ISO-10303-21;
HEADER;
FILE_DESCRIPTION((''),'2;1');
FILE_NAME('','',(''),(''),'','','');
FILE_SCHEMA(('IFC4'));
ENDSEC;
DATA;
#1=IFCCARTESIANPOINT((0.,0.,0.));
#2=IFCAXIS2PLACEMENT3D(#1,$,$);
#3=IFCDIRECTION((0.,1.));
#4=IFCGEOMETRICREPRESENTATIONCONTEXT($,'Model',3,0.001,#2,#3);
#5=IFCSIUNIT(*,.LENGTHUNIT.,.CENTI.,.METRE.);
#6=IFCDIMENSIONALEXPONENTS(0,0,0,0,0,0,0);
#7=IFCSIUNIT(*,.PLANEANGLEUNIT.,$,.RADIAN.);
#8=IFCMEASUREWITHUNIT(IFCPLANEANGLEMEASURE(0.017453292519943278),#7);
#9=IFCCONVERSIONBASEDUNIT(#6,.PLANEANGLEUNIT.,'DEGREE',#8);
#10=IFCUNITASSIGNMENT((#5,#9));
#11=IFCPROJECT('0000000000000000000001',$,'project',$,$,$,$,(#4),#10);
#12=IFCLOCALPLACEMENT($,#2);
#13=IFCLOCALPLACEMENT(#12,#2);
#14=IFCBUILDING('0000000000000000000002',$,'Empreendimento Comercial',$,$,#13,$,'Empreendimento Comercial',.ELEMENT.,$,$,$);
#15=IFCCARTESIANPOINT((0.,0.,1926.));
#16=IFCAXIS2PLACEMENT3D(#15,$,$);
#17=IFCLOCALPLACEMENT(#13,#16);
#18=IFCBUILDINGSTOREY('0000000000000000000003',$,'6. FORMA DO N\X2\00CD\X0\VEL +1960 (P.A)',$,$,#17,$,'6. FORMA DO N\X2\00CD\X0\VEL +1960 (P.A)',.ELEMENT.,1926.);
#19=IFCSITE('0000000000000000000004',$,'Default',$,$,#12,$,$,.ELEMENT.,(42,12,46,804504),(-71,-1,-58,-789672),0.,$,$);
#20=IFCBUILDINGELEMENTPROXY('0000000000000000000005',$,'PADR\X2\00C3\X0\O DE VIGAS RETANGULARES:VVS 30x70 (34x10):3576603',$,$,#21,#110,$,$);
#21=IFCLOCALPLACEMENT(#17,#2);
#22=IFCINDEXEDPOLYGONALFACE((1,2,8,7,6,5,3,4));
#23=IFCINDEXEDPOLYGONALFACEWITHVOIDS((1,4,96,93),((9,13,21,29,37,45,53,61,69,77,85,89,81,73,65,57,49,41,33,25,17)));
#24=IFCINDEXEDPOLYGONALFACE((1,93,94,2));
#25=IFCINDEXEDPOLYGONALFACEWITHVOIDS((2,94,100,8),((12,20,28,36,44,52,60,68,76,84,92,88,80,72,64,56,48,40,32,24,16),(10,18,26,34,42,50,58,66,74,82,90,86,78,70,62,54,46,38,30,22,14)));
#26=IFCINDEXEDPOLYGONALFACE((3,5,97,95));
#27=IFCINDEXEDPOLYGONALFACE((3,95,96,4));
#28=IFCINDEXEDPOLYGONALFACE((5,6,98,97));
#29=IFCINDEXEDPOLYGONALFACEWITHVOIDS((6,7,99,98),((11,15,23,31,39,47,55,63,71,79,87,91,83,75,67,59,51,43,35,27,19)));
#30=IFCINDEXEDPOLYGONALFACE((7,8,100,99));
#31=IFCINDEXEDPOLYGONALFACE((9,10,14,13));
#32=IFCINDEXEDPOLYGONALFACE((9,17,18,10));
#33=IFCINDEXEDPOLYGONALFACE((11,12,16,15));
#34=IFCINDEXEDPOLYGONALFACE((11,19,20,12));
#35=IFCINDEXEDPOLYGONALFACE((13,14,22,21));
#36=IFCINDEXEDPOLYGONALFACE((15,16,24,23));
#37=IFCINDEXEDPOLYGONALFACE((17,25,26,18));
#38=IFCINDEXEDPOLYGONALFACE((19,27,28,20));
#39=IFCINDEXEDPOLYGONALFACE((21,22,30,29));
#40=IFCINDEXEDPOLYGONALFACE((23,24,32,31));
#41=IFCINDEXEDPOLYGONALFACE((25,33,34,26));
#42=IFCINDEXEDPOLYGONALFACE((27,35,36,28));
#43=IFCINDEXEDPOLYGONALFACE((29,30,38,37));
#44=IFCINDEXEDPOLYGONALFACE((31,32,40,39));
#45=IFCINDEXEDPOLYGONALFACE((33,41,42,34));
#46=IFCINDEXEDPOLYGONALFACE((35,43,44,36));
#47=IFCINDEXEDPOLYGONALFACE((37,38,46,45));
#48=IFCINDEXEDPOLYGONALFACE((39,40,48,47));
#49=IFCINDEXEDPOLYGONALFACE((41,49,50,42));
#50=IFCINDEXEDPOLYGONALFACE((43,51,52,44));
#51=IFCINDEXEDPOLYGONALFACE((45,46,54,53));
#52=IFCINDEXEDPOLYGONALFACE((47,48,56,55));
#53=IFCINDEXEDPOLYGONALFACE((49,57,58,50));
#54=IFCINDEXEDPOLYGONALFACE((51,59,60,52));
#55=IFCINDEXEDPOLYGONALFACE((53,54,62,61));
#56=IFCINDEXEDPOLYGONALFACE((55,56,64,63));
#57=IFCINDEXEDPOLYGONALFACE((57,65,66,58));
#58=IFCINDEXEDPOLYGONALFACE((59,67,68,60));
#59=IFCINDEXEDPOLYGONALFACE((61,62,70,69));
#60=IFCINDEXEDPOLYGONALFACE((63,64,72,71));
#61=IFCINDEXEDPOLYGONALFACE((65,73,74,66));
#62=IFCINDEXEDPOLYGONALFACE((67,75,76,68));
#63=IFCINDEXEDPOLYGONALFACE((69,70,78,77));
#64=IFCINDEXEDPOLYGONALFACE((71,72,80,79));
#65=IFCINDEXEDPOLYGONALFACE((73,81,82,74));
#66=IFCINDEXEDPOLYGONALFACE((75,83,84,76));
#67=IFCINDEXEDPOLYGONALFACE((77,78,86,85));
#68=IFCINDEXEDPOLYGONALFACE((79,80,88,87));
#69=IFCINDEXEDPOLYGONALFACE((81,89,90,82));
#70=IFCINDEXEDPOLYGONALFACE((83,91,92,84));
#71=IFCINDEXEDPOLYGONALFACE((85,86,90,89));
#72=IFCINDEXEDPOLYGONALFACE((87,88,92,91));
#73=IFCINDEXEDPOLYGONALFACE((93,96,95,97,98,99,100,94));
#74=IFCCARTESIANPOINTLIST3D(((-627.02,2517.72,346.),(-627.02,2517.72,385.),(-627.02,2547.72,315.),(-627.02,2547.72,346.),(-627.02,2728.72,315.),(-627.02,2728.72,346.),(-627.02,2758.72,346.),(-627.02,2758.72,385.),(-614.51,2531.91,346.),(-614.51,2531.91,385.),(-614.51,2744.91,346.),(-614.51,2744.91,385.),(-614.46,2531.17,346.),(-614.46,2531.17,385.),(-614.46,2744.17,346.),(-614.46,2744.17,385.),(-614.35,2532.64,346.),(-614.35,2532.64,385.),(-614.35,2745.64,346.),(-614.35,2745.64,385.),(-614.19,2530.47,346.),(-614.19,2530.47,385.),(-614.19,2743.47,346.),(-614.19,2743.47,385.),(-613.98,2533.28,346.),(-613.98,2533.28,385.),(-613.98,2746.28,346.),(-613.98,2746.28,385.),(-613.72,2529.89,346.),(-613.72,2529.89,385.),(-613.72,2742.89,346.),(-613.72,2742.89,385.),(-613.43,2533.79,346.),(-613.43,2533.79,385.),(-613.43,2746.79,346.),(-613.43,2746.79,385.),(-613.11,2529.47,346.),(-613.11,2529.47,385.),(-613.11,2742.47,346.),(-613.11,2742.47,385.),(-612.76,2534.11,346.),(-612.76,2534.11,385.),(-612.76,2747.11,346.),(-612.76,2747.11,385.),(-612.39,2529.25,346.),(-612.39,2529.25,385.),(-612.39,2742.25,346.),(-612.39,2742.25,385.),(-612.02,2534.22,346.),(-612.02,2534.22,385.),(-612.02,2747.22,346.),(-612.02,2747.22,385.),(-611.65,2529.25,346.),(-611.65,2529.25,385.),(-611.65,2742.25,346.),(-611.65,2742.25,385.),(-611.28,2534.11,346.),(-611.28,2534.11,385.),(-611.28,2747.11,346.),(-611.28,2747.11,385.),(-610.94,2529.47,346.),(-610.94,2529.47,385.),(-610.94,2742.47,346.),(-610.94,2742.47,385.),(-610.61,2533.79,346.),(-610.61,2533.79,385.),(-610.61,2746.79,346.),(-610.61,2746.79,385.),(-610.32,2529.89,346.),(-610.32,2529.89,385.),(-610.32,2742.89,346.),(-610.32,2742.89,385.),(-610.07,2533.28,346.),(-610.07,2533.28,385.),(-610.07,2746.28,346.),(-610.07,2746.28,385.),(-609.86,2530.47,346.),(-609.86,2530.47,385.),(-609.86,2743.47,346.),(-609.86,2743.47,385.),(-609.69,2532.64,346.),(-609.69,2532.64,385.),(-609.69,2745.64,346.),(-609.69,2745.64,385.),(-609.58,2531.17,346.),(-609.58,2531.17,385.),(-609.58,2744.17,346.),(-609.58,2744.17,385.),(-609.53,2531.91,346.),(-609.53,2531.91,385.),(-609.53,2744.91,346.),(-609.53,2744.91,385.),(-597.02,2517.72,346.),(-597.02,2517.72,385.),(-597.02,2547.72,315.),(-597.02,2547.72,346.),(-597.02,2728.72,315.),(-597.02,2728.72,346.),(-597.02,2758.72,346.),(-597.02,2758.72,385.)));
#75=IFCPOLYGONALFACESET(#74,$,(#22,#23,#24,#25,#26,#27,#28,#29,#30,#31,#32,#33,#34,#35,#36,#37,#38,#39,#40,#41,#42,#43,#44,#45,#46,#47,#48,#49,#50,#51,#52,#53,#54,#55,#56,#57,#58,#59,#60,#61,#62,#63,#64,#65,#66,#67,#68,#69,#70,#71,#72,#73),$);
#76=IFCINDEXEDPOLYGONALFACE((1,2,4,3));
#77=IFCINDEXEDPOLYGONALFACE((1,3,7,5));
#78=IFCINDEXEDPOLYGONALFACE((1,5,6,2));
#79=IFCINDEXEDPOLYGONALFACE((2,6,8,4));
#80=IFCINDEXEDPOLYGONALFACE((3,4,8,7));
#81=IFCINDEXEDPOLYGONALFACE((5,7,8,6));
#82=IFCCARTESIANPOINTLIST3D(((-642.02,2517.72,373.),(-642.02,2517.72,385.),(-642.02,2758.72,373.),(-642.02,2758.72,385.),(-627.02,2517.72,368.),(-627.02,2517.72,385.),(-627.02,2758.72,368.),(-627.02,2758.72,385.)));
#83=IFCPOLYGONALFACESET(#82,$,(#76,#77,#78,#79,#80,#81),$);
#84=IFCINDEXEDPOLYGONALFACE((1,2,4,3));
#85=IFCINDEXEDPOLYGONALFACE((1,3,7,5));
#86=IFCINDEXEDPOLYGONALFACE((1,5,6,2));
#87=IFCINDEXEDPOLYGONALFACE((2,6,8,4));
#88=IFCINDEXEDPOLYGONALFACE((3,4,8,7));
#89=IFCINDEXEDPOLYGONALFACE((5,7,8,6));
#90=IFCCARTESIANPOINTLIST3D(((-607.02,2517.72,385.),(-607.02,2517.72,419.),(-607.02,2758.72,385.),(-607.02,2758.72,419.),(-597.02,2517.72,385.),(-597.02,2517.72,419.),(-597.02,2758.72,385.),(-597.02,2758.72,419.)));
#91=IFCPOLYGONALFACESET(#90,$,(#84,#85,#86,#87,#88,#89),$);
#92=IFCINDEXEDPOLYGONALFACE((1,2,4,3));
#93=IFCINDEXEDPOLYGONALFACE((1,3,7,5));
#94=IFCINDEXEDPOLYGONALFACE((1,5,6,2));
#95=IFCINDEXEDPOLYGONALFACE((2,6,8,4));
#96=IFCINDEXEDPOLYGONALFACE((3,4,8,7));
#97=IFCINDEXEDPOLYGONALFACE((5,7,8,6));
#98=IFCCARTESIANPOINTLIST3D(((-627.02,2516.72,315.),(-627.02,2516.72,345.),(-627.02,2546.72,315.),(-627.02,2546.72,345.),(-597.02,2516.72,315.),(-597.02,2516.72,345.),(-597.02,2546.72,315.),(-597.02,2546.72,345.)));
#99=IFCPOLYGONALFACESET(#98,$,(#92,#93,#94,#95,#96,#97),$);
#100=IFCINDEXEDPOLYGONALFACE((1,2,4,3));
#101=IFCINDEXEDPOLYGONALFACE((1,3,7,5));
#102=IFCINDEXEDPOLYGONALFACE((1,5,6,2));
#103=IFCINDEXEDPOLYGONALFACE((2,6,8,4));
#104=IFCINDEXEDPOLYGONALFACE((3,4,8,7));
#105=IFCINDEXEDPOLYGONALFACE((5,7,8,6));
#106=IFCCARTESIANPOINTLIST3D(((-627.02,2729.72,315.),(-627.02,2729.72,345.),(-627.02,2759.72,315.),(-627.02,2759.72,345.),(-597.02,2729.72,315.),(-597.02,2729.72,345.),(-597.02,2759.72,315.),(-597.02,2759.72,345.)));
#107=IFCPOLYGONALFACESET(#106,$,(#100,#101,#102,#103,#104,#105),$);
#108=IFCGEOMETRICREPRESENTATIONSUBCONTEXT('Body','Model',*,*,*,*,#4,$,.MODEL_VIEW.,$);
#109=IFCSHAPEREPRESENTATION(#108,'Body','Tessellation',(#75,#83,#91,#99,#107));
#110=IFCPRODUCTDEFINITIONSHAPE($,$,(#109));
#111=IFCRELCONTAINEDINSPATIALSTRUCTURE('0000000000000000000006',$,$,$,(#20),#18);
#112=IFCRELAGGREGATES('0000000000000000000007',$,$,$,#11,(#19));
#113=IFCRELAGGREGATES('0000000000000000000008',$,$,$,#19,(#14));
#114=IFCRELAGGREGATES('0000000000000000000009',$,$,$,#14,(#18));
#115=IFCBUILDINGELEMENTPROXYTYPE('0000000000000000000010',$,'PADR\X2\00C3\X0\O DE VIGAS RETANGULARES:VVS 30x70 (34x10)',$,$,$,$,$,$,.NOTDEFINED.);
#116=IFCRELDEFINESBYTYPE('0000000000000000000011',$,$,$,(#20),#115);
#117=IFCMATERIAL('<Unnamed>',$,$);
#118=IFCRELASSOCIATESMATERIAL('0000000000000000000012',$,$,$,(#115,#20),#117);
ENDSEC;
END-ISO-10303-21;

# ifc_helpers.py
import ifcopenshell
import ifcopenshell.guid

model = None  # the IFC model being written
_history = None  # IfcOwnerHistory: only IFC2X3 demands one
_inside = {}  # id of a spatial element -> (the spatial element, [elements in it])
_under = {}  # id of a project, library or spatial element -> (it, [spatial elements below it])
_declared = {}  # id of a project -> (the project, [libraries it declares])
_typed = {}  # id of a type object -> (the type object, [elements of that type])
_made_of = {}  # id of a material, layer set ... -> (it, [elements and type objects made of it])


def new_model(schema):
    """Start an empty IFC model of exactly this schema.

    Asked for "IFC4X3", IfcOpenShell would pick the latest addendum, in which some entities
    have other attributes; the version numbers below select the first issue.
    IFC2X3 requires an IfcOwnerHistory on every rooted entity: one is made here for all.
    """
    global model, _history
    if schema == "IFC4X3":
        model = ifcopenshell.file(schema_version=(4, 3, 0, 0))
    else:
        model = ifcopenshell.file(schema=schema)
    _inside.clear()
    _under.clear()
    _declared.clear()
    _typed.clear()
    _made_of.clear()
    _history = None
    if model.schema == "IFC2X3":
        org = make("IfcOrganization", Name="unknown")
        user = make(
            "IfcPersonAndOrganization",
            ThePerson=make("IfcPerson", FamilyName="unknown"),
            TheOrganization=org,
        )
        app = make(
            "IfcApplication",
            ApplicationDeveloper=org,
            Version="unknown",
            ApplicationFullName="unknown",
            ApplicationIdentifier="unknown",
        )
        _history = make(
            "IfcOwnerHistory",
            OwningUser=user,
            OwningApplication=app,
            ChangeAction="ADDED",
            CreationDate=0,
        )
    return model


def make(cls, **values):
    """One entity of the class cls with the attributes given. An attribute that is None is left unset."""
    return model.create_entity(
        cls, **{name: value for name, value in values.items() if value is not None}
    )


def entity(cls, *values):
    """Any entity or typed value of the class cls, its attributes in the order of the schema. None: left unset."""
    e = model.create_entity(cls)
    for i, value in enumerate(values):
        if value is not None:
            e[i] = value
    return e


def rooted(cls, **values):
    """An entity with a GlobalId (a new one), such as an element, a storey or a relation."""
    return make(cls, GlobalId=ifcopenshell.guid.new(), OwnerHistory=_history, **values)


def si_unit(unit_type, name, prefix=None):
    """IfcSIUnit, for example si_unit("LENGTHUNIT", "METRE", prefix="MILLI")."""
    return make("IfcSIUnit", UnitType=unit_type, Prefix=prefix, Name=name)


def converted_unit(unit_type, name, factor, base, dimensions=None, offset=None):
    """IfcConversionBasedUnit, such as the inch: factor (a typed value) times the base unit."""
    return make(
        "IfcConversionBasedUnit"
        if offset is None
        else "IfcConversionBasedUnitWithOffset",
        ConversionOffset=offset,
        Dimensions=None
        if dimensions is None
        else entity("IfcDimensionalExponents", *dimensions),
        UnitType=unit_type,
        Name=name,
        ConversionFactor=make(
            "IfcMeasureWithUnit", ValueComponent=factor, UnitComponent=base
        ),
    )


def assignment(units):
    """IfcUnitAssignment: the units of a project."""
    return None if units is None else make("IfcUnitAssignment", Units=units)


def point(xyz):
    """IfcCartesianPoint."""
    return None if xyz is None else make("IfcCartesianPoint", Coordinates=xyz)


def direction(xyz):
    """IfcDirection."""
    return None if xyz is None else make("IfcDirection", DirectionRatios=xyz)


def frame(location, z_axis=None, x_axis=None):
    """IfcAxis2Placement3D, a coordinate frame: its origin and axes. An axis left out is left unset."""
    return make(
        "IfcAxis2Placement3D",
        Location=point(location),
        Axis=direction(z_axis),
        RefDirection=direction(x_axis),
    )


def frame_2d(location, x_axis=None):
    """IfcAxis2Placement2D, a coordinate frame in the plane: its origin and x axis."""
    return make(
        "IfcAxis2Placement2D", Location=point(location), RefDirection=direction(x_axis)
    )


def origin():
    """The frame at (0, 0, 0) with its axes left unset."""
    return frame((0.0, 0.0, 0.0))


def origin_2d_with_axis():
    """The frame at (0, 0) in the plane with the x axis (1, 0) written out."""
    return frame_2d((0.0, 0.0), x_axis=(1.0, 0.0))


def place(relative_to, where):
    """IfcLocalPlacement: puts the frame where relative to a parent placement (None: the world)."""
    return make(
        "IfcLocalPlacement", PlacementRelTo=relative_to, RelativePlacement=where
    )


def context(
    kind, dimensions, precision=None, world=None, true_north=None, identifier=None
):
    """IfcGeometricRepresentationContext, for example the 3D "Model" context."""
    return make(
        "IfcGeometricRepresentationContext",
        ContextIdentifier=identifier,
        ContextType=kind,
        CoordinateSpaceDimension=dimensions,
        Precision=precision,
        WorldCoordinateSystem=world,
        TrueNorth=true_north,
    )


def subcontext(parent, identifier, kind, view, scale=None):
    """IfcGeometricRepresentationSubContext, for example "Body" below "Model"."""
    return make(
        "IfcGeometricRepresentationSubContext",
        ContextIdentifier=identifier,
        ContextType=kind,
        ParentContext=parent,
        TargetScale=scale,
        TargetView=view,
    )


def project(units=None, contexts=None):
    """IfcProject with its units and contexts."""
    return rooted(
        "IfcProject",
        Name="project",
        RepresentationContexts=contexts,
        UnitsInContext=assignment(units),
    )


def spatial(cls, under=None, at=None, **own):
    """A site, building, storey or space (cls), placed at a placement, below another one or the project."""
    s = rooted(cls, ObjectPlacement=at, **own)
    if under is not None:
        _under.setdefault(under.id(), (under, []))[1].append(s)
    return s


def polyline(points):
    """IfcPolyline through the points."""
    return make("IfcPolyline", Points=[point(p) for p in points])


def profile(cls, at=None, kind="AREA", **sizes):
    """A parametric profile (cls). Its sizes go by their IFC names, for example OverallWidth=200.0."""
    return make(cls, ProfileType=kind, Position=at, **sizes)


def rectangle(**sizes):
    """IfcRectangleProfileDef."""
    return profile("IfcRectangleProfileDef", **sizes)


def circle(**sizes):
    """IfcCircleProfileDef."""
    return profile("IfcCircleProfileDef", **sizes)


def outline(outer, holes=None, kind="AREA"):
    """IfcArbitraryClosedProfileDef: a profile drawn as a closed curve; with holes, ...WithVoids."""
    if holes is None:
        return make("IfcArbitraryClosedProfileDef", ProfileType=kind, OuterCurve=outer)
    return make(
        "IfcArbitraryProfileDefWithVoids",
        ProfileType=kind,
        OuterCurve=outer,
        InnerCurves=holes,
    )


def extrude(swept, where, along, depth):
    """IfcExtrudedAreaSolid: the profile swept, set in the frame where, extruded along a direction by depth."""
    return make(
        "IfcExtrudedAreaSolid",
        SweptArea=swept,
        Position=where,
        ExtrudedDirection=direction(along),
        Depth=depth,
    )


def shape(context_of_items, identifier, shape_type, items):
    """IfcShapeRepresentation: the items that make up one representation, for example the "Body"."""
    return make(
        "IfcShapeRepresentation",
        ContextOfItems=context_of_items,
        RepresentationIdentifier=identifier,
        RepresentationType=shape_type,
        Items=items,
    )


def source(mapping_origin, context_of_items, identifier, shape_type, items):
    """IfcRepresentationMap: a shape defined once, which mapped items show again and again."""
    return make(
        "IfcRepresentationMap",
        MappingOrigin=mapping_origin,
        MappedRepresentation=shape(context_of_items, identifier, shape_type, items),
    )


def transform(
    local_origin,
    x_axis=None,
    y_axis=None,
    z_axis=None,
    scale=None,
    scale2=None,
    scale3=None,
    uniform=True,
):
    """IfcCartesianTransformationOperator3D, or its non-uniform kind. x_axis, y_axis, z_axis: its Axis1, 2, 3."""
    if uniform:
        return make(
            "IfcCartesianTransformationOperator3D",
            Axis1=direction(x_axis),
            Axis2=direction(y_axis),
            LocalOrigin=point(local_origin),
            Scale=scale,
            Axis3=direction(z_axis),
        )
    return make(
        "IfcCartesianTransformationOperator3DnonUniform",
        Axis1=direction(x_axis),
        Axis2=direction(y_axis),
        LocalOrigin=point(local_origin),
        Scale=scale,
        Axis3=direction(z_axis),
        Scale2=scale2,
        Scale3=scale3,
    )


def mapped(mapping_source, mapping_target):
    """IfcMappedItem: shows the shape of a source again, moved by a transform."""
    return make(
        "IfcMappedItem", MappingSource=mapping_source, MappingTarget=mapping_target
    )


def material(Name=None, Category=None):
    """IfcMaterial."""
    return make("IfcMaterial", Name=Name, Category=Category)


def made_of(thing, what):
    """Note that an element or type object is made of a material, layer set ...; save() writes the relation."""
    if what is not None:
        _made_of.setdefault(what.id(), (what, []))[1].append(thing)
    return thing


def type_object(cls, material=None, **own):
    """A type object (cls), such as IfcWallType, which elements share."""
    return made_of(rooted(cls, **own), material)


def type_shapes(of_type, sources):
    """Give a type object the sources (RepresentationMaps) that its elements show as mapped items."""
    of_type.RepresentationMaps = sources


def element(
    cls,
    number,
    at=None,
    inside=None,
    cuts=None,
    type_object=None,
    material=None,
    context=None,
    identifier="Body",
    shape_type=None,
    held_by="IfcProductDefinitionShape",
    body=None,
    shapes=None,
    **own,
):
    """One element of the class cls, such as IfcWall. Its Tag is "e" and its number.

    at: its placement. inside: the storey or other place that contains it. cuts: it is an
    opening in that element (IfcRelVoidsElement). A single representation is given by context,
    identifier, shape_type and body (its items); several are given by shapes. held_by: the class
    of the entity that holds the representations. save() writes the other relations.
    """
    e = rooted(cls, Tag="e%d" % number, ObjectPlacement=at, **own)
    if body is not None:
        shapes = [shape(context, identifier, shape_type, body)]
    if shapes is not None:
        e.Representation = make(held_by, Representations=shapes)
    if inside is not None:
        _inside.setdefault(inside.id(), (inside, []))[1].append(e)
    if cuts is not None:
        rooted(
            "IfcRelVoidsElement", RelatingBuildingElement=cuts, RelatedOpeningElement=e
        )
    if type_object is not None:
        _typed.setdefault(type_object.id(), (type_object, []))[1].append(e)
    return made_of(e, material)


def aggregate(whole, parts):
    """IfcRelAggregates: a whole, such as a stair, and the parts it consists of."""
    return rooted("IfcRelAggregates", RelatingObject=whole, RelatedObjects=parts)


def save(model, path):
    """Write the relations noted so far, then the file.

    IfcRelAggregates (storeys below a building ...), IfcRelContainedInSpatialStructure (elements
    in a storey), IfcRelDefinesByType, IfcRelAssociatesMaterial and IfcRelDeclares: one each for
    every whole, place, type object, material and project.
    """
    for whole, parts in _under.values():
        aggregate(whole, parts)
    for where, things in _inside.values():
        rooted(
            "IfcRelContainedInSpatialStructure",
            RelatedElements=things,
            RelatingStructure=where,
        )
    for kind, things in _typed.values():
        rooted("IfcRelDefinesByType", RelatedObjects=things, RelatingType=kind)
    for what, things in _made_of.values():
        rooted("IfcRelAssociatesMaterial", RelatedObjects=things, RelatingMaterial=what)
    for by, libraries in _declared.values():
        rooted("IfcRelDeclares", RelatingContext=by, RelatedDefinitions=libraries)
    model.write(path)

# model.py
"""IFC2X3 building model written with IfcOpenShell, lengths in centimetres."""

from ifc_helpers import new_model, entity, si_unit, converted_unit, direction, frame, frame_2d, origin, origin_2d_with_axis, place, context, subcontext, project, spatial, polyline, rectangle, circle, outline, extrude, source, transform, mapped, material, type_object, type_shapes, element, save


model = new_model("IFC2X3")

# Units and contexts
model_context = context("Model", 3, precision=0.001, world=origin(), true_north=direction((0.0, 1.0)))
body_context = subcontext(model_context, "Body", "Model", "MODEL_VIEW")
ifc_project = project(units=[si_unit("LENGTHUNIT", "METRE", prefix="CENTI"), converted_unit("PLANEANGLEUNIT", "DEGREE", entity("IfcPlaneAngleMeasure", 0.017453292519943278), si_unit("PLANEANGLEUNIT", "RADIAN"), dimensions=[0, 0, 0, 0, 0, 0, 0])], contexts=[model_context])

# Site, building, storey
site_placement = place(None, origin())
site = spatial("IfcSite", under=ifc_project, at=site_placement, Name="Default", CompositionType="ELEMENT", RefLatitude=(42, 12, 46, 804504), RefLongitude=(-71, -1, -58, -789672), RefElevation=0.0)
building_placement = place(site_placement, origin())
building = spatial("IfcBuilding", under=site, at=building_placement, Name="Empreendimento Comercial", LongName="Empreendimento Comercial", CompositionType="ELEMENT")
storey_placement = place(building_placement, frame((0.0, 0.0, 1926.0)))
storey = spatial("IfcBuildingStorey", under=building, at=storey_placement, Name="6. FORMA DO NÍVEL +1960 (P.A)", LongName="6. FORMA DO NÍVEL +1960 (P.A)", CompositionType="ELEMENT", Elevation=1926.0)

# Shared definitions
ifc_material = material(Name="<Unnamed>")

# Building element proxy, openings
building_element_proxy_type_1 = type_object("IfcBuildingElementProxyType", Name="PADRÃO DE VIGAS RETANGULARES:VVS 30x70 (34x10)", PredefinedType="NOTDEFINED", material=ifc_material)
shared_shape_1 = source(origin(), body_context, "Body", "SweptSolid", [
    extrude(outline(polyline([(-120.5, -37.0), (120.5, -37.0), (120.5, 2.0), (90.5, 2.0), (90.5, 33.0), (-90.5, 33.0), (-90.5, 2.0), (-120.5, 2.0), (-120.5, -37.0)])), frame((-627.02, 2638.22, 2274.0), z_axis=(1.0, 0.0, 0.0), x_axis=(0.0, -1.0, 0.0)), (0.0, 0.0, 1.0), 30.0),
    extrude(outline(polyline([(-7.5, -7.25), (7.5, -7.25), (7.5, 9.75), (-7.5, 4.75), (-7.5, -7.25)])), frame((-634.52, 2517.72, 2303.75), z_axis=(0.0, 1.0, 0.0), x_axis=(1.0, 0.0, 0.0)), (0.0, 0.0, 1.0), 241.0),
    extrude(rectangle(XDim=10.0, YDim=241.0, at=frame_2d((0.0, 0.0), x_axis=(1.0, 0.0))), frame((-602.02, 2638.22, 2311.0), z_axis=(0.0, 0.0, 1.0), x_axis=(-1.0, 0.0, 0.0)), (0.0, 0.0, 1.0), 34.0),
    extrude(rectangle(XDim=30.0, YDim=30.0, at=frame_2d((0.0, 0.0), x_axis=(1.0, 0.0))), frame((-612.02, 2531.72, 2241.0), z_axis=(0.0, 0.0, 1.0), x_axis=(0.0, -1.0, 0.0)), (0.0, 0.0, 1.0), 30.0),
    extrude(rectangle(XDim=30.0, YDim=30.0, at=frame_2d((0.0, 0.0), x_axis=(1.0, 0.0))), frame((-612.02, 2744.72, 2241.0), z_axis=(0.0, 0.0, 1.0), x_axis=(0.0, -1.0, 0.0)), (0.0, 0.0, 1.0), 30.0),
])
type_shapes(building_element_proxy_type_1, [shared_shape_1])
proxy_1_placement = place(storey_placement, frame((0.0, 0.0, -1926.0)))
proxy_1 = element("IfcBuildingElementProxy", 1, at=proxy_1_placement, inside=storey, type_object=building_element_proxy_type_1, material=ifc_material, Name="PADRÃO DE VIGAS RETANGULARES:VVS 30x70 (34x10):3576603", context=body_context, shape_type="MappedRepresentation", body=[
    mapped(shared_shape_1, transform((0.0, 0.0, 0.0), scale=1.0)),
])
opening_1_placement = place(storey_placement, frame((0.0, 0.0, -1926.0)))
element("IfcOpeningElement", 2, at=opening_1_placement, cuts=proxy_1, ObjectType="Opening", context=body_context, shape_type="SweptSolid", body=[
    extrude(circle(Radius=2.5, at=origin_2d_with_axis()), frame((-612.02, 2531.72, 2311.0), z_axis=(0.0, 0.0, -1.0), x_axis=(0.0, 1.0, 0.0)), (0.0, 0.0, 1.0), 39.0),
])
opening_2_placement = place(storey_placement, frame((0.0, 0.0, -1926.0)))
element("IfcOpeningElement", 3, at=opening_2_placement, cuts=proxy_1, ObjectType="Opening", context=body_context, shape_type="SweptSolid", body=[
    extrude(circle(Radius=2.5, at=origin_2d_with_axis()), frame((-612.02, 2744.72, 2272.0), z_axis=(0.0, 0.0, 1.0), x_axis=(0.0, 1.0, 0.0)), (0.0, 0.0, 1.0), 39.0),
])

save(model, "model.ifc")
